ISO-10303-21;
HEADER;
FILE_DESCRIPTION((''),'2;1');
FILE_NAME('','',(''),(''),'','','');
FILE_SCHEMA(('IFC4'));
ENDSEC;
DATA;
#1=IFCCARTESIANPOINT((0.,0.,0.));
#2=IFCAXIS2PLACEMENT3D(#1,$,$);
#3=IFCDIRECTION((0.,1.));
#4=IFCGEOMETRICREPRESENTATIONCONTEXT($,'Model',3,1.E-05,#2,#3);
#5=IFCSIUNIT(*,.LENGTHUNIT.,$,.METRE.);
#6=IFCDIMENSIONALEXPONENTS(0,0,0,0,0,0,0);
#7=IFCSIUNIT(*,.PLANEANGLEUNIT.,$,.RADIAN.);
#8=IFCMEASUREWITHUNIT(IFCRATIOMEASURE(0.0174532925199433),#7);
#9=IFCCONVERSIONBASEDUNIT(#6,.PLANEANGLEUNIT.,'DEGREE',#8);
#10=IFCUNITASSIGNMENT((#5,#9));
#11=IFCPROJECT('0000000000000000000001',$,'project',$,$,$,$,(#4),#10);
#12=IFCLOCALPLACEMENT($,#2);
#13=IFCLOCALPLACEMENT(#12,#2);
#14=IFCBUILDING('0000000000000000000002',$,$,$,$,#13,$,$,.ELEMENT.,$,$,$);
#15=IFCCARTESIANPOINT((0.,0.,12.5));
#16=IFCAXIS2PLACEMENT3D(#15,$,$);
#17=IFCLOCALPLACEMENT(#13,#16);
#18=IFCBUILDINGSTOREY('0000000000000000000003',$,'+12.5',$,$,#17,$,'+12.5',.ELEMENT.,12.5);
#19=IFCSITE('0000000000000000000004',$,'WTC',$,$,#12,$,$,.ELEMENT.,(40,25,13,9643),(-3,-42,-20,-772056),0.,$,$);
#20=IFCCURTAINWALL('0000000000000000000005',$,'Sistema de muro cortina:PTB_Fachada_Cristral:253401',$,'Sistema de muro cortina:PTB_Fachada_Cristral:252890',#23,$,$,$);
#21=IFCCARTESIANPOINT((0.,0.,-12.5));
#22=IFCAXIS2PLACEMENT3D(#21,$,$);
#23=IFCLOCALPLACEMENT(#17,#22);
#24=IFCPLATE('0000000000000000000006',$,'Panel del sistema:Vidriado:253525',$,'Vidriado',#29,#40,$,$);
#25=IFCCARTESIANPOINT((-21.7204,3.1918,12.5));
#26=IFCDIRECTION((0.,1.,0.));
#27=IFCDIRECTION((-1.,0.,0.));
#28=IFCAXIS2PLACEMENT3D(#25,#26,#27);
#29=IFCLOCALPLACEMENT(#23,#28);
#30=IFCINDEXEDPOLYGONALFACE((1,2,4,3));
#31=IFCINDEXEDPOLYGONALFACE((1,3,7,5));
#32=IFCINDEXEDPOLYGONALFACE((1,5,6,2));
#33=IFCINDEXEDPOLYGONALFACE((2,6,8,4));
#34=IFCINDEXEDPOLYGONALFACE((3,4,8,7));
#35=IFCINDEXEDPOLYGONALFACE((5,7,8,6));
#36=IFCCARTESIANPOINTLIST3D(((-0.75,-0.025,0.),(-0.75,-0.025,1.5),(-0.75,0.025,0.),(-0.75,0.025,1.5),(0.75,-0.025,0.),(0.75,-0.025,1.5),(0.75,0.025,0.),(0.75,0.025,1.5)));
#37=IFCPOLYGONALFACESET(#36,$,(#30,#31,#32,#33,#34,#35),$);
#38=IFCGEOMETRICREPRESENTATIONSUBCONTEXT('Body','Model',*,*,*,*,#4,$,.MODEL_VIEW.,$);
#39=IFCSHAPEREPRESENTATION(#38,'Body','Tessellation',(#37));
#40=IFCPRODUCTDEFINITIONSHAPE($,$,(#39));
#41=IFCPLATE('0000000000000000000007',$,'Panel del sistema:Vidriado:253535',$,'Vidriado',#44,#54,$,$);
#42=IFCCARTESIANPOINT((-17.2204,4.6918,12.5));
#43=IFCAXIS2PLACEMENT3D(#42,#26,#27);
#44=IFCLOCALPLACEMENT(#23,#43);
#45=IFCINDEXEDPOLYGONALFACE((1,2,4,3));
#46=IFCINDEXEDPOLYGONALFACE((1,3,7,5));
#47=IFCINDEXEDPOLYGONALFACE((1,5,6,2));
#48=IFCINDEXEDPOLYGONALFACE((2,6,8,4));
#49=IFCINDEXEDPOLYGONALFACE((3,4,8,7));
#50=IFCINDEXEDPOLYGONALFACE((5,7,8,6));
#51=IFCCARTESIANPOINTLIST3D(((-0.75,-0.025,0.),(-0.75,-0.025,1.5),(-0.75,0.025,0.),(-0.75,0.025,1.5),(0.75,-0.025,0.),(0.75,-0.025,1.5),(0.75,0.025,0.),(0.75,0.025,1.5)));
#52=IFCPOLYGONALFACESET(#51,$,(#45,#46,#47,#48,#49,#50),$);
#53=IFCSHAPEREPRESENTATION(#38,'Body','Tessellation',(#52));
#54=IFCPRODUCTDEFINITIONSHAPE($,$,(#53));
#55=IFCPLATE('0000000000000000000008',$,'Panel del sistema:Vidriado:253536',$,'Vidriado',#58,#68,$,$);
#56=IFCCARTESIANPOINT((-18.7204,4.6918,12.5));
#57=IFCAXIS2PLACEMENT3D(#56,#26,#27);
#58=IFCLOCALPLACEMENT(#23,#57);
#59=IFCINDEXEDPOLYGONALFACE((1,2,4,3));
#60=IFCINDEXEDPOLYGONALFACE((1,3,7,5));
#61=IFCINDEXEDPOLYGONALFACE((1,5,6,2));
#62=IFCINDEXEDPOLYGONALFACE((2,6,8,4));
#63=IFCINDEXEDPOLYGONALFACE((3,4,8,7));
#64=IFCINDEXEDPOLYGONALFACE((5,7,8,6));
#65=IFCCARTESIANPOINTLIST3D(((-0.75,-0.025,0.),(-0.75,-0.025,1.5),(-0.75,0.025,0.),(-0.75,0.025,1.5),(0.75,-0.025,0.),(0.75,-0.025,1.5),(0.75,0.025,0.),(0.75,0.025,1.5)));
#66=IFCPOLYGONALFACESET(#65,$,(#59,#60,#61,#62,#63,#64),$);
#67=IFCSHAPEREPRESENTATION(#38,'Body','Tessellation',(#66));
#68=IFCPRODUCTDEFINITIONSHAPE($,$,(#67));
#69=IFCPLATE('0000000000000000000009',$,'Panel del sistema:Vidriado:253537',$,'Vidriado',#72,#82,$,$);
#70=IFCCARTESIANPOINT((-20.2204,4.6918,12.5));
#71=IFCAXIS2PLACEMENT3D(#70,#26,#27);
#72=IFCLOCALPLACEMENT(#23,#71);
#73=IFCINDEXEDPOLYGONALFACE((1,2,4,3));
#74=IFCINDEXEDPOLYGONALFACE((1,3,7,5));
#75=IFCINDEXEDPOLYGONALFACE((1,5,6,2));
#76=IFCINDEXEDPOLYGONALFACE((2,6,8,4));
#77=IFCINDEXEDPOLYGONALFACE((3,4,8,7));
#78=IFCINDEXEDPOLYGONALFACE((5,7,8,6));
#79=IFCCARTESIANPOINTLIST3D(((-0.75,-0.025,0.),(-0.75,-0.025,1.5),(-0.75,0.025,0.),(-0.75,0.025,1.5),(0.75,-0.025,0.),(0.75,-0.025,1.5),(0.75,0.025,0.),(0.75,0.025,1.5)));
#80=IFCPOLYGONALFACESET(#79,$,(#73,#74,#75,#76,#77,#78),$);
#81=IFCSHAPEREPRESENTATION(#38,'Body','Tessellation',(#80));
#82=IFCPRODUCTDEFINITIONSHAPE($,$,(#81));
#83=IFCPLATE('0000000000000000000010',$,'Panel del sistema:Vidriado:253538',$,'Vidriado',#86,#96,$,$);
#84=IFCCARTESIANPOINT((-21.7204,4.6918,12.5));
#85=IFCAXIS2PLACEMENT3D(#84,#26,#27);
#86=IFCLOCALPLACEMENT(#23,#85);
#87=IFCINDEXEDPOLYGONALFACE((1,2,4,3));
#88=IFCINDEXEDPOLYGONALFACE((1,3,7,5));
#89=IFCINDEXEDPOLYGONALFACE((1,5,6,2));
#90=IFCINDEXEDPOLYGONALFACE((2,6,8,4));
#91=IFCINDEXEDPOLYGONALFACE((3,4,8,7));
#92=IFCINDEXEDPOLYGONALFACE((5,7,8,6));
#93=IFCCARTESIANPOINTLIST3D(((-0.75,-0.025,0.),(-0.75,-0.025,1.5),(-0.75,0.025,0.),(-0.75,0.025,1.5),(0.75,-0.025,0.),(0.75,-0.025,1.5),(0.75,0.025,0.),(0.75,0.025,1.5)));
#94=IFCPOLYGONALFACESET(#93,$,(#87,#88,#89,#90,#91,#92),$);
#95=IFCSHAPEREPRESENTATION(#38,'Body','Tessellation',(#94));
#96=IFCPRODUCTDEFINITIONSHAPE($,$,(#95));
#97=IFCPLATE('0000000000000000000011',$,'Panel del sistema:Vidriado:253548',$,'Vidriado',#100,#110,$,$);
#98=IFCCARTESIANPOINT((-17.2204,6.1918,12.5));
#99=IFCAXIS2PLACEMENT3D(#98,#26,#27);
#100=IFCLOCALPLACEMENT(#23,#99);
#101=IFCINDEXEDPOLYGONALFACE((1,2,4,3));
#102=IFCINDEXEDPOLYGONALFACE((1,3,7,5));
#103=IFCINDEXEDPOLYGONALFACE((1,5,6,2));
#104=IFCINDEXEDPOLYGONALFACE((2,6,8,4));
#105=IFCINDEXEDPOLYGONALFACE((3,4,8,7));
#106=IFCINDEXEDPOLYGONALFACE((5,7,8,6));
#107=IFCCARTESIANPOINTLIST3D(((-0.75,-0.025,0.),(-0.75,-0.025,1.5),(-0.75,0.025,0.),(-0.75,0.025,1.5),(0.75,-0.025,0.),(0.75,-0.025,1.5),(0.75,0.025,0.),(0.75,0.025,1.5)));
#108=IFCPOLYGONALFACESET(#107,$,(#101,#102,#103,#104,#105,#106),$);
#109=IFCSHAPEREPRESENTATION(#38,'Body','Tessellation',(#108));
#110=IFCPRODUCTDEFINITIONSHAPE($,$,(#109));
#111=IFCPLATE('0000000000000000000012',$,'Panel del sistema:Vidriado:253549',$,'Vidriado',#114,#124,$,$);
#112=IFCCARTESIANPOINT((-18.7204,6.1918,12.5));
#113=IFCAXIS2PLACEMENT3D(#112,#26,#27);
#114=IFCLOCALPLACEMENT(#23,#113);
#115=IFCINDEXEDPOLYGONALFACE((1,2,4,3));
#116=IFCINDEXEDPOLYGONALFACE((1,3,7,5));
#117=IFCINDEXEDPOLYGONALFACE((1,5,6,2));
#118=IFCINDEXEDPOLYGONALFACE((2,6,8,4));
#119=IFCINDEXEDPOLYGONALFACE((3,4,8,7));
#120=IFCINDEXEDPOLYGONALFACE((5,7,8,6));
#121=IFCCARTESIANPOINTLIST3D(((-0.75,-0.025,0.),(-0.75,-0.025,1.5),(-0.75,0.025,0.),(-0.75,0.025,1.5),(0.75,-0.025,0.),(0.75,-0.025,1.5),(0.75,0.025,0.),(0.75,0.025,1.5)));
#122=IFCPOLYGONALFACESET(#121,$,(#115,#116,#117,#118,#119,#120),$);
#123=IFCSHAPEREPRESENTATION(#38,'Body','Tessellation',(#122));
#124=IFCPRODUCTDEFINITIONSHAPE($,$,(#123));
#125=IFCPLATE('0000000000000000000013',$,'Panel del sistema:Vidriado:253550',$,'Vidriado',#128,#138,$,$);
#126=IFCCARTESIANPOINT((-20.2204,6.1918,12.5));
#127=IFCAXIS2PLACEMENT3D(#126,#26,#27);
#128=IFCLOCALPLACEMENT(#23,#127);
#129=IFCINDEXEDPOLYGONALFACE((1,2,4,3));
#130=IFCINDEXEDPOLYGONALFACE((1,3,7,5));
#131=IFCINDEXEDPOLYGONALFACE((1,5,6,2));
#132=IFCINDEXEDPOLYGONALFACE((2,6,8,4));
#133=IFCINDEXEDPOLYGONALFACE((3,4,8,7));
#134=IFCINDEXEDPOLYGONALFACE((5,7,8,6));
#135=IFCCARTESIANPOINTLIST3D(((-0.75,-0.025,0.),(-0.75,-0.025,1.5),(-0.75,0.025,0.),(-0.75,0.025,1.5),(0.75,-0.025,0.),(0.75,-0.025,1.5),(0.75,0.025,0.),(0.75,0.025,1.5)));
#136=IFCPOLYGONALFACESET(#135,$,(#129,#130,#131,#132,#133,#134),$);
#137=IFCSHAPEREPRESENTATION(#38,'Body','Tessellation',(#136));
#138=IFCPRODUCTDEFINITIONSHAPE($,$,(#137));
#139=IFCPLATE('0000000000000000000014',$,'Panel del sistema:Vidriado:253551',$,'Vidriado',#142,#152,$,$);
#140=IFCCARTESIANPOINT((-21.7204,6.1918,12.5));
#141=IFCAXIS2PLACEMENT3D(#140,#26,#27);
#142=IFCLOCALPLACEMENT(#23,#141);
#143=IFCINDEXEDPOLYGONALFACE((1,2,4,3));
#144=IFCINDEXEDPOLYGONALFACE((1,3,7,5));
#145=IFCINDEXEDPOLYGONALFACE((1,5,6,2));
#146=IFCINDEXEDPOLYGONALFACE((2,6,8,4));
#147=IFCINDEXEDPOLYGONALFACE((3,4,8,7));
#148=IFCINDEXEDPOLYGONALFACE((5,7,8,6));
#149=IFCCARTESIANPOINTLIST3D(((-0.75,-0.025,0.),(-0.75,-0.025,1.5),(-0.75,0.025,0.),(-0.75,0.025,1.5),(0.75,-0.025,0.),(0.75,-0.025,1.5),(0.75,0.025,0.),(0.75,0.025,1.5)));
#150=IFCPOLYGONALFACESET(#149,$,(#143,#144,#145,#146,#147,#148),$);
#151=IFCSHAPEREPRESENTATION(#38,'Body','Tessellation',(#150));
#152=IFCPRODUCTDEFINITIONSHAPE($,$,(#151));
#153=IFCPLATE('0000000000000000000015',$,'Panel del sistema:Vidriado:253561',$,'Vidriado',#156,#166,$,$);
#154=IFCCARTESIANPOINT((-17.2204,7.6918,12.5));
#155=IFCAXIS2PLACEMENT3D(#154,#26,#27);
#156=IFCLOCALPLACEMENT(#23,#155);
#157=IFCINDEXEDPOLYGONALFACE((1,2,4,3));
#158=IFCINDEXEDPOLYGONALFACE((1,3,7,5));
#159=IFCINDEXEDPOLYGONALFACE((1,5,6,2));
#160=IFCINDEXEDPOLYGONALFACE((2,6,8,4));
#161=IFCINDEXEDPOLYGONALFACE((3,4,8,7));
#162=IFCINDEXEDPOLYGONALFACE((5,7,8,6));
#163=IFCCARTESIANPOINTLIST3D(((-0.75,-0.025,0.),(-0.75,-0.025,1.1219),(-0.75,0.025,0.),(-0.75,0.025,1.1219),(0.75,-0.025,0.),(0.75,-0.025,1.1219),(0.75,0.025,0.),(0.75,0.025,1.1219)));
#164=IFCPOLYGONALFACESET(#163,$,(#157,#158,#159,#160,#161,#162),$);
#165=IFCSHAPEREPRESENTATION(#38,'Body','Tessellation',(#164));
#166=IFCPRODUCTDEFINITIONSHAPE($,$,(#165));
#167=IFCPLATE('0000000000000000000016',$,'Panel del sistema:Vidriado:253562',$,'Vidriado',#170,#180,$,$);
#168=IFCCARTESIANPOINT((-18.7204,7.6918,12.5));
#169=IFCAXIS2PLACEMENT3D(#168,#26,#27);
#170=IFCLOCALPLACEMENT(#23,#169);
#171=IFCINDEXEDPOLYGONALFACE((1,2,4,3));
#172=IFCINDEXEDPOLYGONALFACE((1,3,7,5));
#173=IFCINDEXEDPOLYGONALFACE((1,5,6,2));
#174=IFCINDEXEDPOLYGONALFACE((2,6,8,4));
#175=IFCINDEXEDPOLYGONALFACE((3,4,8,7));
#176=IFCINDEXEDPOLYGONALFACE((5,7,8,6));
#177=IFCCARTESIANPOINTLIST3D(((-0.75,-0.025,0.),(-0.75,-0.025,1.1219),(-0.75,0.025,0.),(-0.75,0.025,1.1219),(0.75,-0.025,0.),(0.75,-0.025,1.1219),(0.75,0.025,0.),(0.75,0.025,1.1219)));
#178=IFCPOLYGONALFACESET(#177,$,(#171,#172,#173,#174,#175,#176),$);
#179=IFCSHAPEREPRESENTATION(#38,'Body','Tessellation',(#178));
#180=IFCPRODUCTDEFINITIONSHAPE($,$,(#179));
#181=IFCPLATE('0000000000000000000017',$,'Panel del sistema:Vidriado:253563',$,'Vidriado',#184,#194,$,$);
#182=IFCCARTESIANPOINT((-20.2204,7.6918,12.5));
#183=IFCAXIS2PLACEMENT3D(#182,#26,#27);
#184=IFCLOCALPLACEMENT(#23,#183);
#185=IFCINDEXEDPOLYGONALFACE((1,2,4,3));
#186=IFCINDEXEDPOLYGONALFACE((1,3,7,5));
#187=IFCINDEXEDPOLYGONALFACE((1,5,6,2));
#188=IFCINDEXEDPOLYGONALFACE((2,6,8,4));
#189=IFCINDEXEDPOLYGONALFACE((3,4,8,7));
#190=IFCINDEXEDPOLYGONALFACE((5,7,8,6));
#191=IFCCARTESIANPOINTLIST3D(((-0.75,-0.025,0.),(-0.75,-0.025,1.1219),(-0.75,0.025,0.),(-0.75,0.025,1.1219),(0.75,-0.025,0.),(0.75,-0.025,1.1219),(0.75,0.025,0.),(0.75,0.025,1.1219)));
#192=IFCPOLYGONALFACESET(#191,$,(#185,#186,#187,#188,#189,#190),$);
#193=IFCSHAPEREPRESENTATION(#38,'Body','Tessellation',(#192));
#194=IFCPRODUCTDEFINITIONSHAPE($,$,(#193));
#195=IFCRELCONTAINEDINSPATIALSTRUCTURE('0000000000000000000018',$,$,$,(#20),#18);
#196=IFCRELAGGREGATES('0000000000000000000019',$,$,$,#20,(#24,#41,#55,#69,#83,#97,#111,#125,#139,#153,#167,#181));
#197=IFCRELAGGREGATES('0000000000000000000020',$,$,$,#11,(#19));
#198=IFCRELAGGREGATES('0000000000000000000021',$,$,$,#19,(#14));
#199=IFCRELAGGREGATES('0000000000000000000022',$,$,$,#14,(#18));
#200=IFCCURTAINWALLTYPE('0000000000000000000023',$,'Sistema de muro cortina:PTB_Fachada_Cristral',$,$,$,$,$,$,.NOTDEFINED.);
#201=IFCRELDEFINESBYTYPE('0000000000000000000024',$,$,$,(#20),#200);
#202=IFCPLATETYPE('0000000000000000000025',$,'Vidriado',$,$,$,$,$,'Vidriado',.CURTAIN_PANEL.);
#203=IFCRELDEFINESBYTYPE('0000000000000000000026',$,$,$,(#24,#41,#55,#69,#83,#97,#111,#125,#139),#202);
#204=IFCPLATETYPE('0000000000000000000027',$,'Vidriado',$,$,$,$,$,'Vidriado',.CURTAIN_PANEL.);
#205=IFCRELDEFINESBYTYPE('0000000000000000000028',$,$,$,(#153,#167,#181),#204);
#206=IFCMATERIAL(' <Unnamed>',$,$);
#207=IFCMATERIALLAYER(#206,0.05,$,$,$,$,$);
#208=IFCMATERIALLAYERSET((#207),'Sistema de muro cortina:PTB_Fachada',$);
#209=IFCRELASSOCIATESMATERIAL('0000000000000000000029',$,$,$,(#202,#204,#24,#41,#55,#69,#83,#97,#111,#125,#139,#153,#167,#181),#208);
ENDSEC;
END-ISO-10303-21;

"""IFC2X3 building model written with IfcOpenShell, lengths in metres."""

from ifc_helpers import new_model, entity, si_unit, converted_unit, direction, frame, origin, origin_2d_with_axis, place, context, subcontext, project, spatial, rectangle, extrude, source, transform, mapped, material, layer, layer_set, layer_usage, type_object, type_shapes, element, aggregate, save


model = new_model("IFC2X3")

# Units and contexts
model_context = context("Model", 3, precision=1e-05, world=origin(), true_north=direction((0.0, 1.0)))
body_context = subcontext(model_context, "Body", "Model", "MODEL_VIEW")
ifc_project = project(units=[si_unit("LENGTHUNIT", "METRE"), converted_unit("PLANEANGLEUNIT", "DEGREE", entity("IfcRatioMeasure", 0.0174532925199433), si_unit("PLANEANGLEUNIT", "RADIAN"), dimensions=[0, 0, 0, 0, 0, 0, 0])], contexts=[model_context])

# Site, building, storey
site_placement = place(None, origin())
site = spatial("IfcSite", under=ifc_project, at=site_placement, Name="WTC", CompositionType="ELEMENT", RefLatitude=(40, 25, 13, 9643), RefLongitude=(-3, -42, -20, -772056), RefElevation=0.0)
building_placement = place(site_placement, origin())
building = spatial("IfcBuilding", under=site, at=building_placement, CompositionType="ELEMENT")
storey_placement = place(building_placement, frame((0.0, 0.0, 12.5)))
storey = spatial("IfcBuildingStorey", under=building, at=storey_placement, Name="+12.5", LongName="+12.5", CompositionType="ELEMENT", Elevation=12.5)

# Curtain wall, plates
curtain_wall_type = type_object("IfcCurtainWallType", Name="Sistema de muro cortina:PTB_Fachada_Cristral", PredefinedType="NOTDEFINED")
curtain_wall_placement = place(storey_placement, frame((0.0, 0.0, -12.5)))
curtain_wall = element("IfcCurtainWall", 1, at=curtain_wall_placement, inside=storey, type_object=curtain_wall_type, Name="Sistema de muro cortina:PTB_Fachada_Cristral:253401", ObjectType="Sistema de muro cortina:PTB_Fachada_Cristral:252890")
ifc_material = material(Name=" <Unnamed>")
ifc_layer = layer(ifc_material, 0.05)
ifc_layer_set = layer_set([ifc_layer], Name="Sistema de muro cortina:PTB_Fachada")
plate_type_1 = type_object("IfcPlateType", Name="Vidriado", ElementType="Vidriado", PredefinedType="CURTAIN_PANEL", material=ifc_layer_set)
shared_shape_1 = source(origin(), body_context, "Body", "SweptSolid", [
    extrude(rectangle(XDim=0.05, YDim=1.5, at=origin_2d_with_axis()), frame((0.0, 0.0, 0.0), z_axis=(0.0, 0.0, 1.0), x_axis=(0.0, 1.0, 0.0)), (0.0, 0.0, 1.0), 1.5),
])
type_shapes(plate_type_1, [shared_shape_1])
ifc_layer_usage_1 = layer_usage(ifc_layer_set, "AXIS3", "POSITIVE", 0.0)
plate_1_placement = place(curtain_wall_placement, frame((-21.7204, 3.1918, 12.5), z_axis=(0.0, 1.0, 0.0), x_axis=(-1.0, 0.0, 0.0)))
plate_1 = element("IfcPlate", 2, at=plate_1_placement, type_object=plate_type_1, material=ifc_layer_usage_1, Name="Panel del sistema:Vidriado:253525", ObjectType="Vidriado", context=body_context, shape_type="MappedRepresentation", body=[
    mapped(shared_shape_1, transform((0.0, 0.0, 0.0), scale=1.0)),
])
ifc_layer_usage_2 = layer_usage(ifc_layer_set, "AXIS3", "POSITIVE", 0.0)
plate_2_placement = place(curtain_wall_placement, frame((-17.2204, 4.6918, 12.5), z_axis=(0.0, 1.0, 0.0), x_axis=(-1.0, 0.0, 0.0)))
plate_2 = element("IfcPlate", 3, at=plate_2_placement, type_object=plate_type_1, material=ifc_layer_usage_2, Name="Panel del sistema:Vidriado:253535", ObjectType="Vidriado", context=body_context, shape_type="MappedRepresentation", body=[
    mapped(shared_shape_1, transform((0.0, 0.0, 0.0), scale=1.0)),
])
ifc_layer_usage_3 = layer_usage(ifc_layer_set, "AXIS3", "POSITIVE", 0.0)
plate_3_placement = place(curtain_wall_placement, frame((-18.7204, 4.6918, 12.5), z_axis=(0.0, 1.0, 0.0), x_axis=(-1.0, 0.0, 0.0)))
plate_3 = element("IfcPlate", 4, at=plate_3_placement, type_object=plate_type_1, material=ifc_layer_usage_3, Name="Panel del sistema:Vidriado:253536", ObjectType="Vidriado", context=body_context, shape_type="MappedRepresentation", body=[
    mapped(shared_shape_1, transform((0.0, 0.0, 0.0), scale=1.0)),
])
ifc_layer_usage_4 = layer_usage(ifc_layer_set, "AXIS3", "POSITIVE", 0.0)
plate_4_placement = place(curtain_wall_placement, frame((-20.2204, 4.6918, 12.5), z_axis=(0.0, 1.0, 0.0), x_axis=(-1.0, 0.0, 0.0)))
plate_4 = element("IfcPlate", 5, at=plate_4_placement, type_object=plate_type_1, material=ifc_layer_usage_4, Name="Panel del sistema:Vidriado:253537", ObjectType="Vidriado", context=body_context, shape_type="MappedRepresentation", body=[
    mapped(shared_shape_1, transform((0.0, 0.0, 0.0), scale=1.0)),
])
ifc_layer_usage_5 = layer_usage(ifc_layer_set, "AXIS3", "POSITIVE", 0.0)
plate_5_placement = place(curtain_wall_placement, frame((-21.7204, 4.6918, 12.5), z_axis=(0.0, 1.0, 0.0), x_axis=(-1.0, 0.0, 0.0)))
plate_5 = element("IfcPlate", 6, at=plate_5_placement, type_object=plate_type_1, material=ifc_layer_usage_5, Name="Panel del sistema:Vidriado:253538", ObjectType="Vidriado", context=body_context, shape_type="MappedRepresentation", body=[
    mapped(shared_shape_1, transform((0.0, 0.0, 0.0), scale=1.0)),
])
ifc_layer_usage_6 = layer_usage(ifc_layer_set, "AXIS3", "POSITIVE", 0.0)
plate_6_placement = place(curtain_wall_placement, frame((-17.2204, 6.1918, 12.5), z_axis=(0.0, 1.0, 0.0), x_axis=(-1.0, 0.0, 0.0)))
plate_6 = element("IfcPlate", 7, at=plate_6_placement, type_object=plate_type_1, material=ifc_layer_usage_6, Name="Panel del sistema:Vidriado:253548", ObjectType="Vidriado", context=body_context, shape_type="MappedRepresentation", body=[
    mapped(shared_shape_1, transform((0.0, 0.0, 0.0), scale=1.0)),
])
ifc_layer_usage_7 = layer_usage(ifc_layer_set, "AXIS3", "POSITIVE", 0.0)
plate_7_placement = place(curtain_wall_placement, frame((-18.7204, 6.1918, 12.5), z_axis=(0.0, 1.0, 0.0), x_axis=(-1.0, 0.0, 0.0)))
plate_7 = element("IfcPlate", 8, at=plate_7_placement, type_object=plate_type_1, material=ifc_layer_usage_7, Name="Panel del sistema:Vidriado:253549", ObjectType="Vidriado", context=body_context, shape_type="MappedRepresentation", body=[
    mapped(shared_shape_1, transform((0.0, 0.0, 0.0), scale=1.0)),
])
ifc_layer_usage_8 = layer_usage(ifc_layer_set, "AXIS3", "POSITIVE", 0.0)
plate_8_placement = place(curtain_wall_placement, frame((-20.2204, 6.1918, 12.5), z_axis=(0.0, 1.0, 0.0), x_axis=(-1.0, 0.0, 0.0)))
plate_8 = element("IfcPlate", 9, at=plate_8_placement, type_object=plate_type_1, material=ifc_layer_usage_8, Name="Panel del sistema:Vidriado:253550", ObjectType="Vidriado", context=body_context, shape_type="MappedRepresentation", body=[
    mapped(shared_shape_1, transform((0.0, 0.0, 0.0), scale=1.0)),
])
ifc_layer_usage_9 = layer_usage(ifc_layer_set, "AXIS3", "POSITIVE", 0.0)
plate_9_placement = place(curtain_wall_placement, frame((-21.7204, 6.1918, 12.5), z_axis=(0.0, 1.0, 0.0), x_axis=(-1.0, 0.0, 0.0)))
plate_9 = element("IfcPlate", 10, at=plate_9_placement, type_object=plate_type_1, material=ifc_layer_usage_9, Name="Panel del sistema:Vidriado:253551", ObjectType="Vidriado", context=body_context, shape_type="MappedRepresentation", body=[
    mapped(shared_shape_1, transform((0.0, 0.0, 0.0), scale=1.0)),
])
ifc_layer_usage_10 = layer_usage(ifc_layer_set, "AXIS3", "POSITIVE", 0.0)
plate_type_2 = type_object("IfcPlateType", Name="Vidriado", ElementType="Vidriado", PredefinedType="CURTAIN_PANEL", material=ifc_layer_set)
shared_shape_2 = source(origin(), body_context, "Body", "SweptSolid", [
    extrude(rectangle(XDim=0.05, YDim=1.5, at=origin_2d_with_axis()), frame((0.0, 0.0, 0.0), z_axis=(0.0, 0.0, 1.0), x_axis=(0.0, 1.0, 0.0)), (0.0, 0.0, 1.0), 1.1219),
])
type_shapes(plate_type_2, [shared_shape_2])
plate_10_placement = place(curtain_wall_placement, frame((-17.2204, 7.6918, 12.5), z_axis=(0.0, 1.0, 0.0), x_axis=(-1.0, 0.0, 0.0)))
plate_10 = element("IfcPlate", 11, at=plate_10_placement, type_object=plate_type_2, material=ifc_layer_usage_10, Name="Panel del sistema:Vidriado:253561", ObjectType="Vidriado", context=body_context, shape_type="MappedRepresentation", body=[
    mapped(shared_shape_2, transform((0.0, 0.0, 0.0), scale=1.0)),
])
ifc_layer_usage_11 = layer_usage(ifc_layer_set, "AXIS3", "POSITIVE", 0.0)
plate_11_placement = place(curtain_wall_placement, frame((-18.7204, 7.6918, 12.5), z_axis=(0.0, 1.0, 0.0), x_axis=(-1.0, 0.0, 0.0)))
plate_11 = element("IfcPlate", 12, at=plate_11_placement, type_object=plate_type_2, material=ifc_layer_usage_11, Name="Panel del sistema:Vidriado:253562", ObjectType="Vidriado", context=body_context, shape_type="MappedRepresentation", body=[
    mapped(shared_shape_2, transform((0.0, 0.0, 0.0), scale=1.0)),
])
ifc_layer_usage_12 = layer_usage(ifc_layer_set, "AXIS3", "POSITIVE", 0.0)
plate_12_placement = place(curtain_wall_placement, frame((-20.2204, 7.6918, 12.5), z_axis=(0.0, 1.0, 0.0), x_axis=(-1.0, 0.0, 0.0)))
plate_12 = element("IfcPlate", 13, at=plate_12_placement, type_object=plate_type_2, material=ifc_layer_usage_12, Name="Panel del sistema:Vidriado:253563", ObjectType="Vidriado", context=body_context, shape_type="MappedRepresentation", body=[
    mapped(shared_shape_2, transform((0.0, 0.0, 0.0), scale=1.0)),
])
aggregate(curtain_wall, [plate_1, plate_2, plate_3, plate_4, plate_5, plate_6, plate_7, plate_8, plate_9, plate_10, plate_11, plate_12])

save(model, "model.ifc")
